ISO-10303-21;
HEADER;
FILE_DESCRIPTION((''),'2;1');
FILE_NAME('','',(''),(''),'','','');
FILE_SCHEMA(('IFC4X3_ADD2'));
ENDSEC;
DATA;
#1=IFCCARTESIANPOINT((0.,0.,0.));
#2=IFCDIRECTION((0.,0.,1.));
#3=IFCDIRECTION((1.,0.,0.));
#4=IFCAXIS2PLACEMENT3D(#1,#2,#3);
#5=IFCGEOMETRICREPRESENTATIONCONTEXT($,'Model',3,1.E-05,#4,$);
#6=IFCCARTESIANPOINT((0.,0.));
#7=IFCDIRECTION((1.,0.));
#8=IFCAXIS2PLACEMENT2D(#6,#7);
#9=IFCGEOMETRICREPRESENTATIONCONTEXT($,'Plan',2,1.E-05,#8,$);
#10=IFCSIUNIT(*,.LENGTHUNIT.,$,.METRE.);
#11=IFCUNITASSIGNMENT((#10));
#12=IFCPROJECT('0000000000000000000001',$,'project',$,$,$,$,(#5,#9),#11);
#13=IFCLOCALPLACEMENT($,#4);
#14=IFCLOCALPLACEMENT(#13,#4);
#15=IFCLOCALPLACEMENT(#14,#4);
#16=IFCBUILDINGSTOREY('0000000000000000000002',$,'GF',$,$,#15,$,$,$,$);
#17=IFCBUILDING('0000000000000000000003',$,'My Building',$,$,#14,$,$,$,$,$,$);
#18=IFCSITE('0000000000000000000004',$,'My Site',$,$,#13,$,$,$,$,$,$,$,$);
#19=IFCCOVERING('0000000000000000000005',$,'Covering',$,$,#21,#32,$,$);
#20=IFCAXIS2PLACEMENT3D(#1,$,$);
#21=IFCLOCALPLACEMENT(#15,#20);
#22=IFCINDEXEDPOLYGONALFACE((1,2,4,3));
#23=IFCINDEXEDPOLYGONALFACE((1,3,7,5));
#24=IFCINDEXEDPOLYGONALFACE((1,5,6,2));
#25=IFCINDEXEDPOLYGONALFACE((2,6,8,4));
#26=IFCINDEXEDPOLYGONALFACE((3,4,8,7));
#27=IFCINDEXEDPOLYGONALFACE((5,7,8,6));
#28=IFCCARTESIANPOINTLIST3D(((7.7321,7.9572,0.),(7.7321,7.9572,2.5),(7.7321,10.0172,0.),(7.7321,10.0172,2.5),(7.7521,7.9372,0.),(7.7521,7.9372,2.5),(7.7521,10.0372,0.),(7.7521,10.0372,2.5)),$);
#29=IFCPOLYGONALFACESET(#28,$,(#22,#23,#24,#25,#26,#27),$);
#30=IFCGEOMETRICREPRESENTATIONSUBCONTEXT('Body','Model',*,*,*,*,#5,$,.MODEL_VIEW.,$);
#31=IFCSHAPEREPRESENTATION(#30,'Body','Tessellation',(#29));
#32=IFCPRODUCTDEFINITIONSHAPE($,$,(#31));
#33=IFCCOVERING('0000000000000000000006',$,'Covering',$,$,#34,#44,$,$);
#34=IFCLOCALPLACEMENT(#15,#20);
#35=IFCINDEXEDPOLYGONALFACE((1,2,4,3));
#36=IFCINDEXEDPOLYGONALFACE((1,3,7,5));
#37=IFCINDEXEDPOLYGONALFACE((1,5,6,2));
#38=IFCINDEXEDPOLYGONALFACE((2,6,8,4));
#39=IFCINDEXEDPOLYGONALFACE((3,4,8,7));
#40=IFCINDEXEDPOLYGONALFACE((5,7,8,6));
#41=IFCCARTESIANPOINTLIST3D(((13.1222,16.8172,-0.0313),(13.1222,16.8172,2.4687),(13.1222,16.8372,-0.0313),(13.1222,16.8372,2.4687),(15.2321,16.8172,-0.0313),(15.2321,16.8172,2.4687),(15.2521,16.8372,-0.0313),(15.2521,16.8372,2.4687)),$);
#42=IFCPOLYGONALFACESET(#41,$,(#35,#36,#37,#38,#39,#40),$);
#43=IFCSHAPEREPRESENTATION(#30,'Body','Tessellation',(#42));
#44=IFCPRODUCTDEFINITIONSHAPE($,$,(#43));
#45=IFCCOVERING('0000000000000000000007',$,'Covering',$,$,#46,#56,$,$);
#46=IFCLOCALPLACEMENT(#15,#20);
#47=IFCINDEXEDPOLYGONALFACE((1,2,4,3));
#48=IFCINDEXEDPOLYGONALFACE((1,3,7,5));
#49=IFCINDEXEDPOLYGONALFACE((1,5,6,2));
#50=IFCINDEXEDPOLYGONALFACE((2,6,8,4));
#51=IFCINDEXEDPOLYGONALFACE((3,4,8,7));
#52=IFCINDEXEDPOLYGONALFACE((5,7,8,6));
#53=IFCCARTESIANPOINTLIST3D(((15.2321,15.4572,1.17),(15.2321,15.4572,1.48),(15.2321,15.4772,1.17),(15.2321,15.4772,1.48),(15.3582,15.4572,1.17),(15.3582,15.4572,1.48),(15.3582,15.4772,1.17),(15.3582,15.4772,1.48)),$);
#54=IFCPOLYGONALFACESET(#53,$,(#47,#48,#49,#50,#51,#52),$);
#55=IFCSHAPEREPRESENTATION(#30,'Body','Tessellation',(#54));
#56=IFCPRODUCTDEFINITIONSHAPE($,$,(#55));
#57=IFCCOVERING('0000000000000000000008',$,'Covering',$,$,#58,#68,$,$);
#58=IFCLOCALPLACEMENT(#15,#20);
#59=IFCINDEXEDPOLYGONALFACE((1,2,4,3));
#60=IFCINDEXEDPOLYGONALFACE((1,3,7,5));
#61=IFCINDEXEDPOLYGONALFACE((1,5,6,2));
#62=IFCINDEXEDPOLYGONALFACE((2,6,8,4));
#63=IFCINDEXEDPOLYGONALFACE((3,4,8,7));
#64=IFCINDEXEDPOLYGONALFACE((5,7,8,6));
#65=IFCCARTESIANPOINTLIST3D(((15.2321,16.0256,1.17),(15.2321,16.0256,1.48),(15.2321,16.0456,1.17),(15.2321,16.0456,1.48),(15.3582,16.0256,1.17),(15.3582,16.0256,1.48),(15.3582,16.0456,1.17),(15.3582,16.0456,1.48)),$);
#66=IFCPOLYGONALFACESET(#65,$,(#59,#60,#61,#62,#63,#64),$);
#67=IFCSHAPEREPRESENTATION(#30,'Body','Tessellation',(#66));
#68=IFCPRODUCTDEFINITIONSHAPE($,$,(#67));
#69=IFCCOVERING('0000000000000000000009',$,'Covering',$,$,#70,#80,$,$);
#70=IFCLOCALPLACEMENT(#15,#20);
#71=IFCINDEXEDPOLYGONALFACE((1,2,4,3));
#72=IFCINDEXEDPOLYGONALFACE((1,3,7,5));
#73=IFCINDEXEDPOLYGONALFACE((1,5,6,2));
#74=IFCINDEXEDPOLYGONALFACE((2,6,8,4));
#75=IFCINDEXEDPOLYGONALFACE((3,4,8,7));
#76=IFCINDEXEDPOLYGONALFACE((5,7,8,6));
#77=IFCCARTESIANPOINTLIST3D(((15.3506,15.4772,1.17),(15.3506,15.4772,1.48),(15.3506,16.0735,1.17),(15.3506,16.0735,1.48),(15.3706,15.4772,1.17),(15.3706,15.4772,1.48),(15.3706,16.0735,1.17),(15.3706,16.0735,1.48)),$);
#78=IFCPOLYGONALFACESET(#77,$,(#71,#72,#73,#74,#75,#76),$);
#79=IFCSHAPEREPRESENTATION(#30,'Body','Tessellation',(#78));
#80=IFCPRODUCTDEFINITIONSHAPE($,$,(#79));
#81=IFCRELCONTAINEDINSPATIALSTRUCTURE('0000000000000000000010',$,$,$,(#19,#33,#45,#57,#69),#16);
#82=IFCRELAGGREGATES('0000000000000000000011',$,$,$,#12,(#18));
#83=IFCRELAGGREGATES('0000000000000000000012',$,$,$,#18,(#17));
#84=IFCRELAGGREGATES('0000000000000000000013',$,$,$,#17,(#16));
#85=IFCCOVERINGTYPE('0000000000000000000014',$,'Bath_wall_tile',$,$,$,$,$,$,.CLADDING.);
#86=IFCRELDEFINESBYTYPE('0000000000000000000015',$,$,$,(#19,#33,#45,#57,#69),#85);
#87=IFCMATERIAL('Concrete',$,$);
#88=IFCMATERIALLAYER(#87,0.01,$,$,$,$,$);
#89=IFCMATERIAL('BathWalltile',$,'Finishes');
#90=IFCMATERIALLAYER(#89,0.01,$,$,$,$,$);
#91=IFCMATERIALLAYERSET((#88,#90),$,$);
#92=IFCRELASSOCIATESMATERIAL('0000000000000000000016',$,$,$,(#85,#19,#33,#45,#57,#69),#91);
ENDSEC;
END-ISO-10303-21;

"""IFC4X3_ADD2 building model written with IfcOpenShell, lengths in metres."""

from ifc_helpers import new_model, si_unit, frame, origin_with_axes, origin_2d_with_axis, place, context, subcontext, project, spatial, line, indexed_curve, outline, extrude, material, layer, layer_set, layer_usage, type_object, element, save


model = new_model("IFC4X3_ADD2")

# Units and contexts
model_context = context("Model", 3, precision=1e-05, world=origin_with_axes())
plan_context = context("Plan", 2, precision=1e-05, world=origin_2d_with_axis())
body_context_1 = subcontext(model_context, "Body", "Model", "MODEL_VIEW")
ifc_project = project(units=[si_unit("LENGTHUNIT", "METRE")], contexts=[model_context, plan_context])

# Site, building, storey
site_placement = place(None, origin_with_axes())
site = spatial("IfcSite", under=ifc_project, at=site_placement, Name="My Site")
building_placement = place(site_placement, origin_with_axes())
building = spatial("IfcBuilding", under=site, at=building_placement, Name="My Building")
storey_placement = place(building_placement, origin_with_axes())
storey = spatial("IfcBuildingStorey", under=building, at=storey_placement, Name="GF")

# Coverings
ifc_material_1 = material(Name="Concrete")
ifc_layer_1 = layer(ifc_material_1, 0.01)
ifc_material_2 = material(Name="BathWalltile", Category="Finishes")
ifc_layer_2 = layer(ifc_material_2, 0.01)
ifc_layer_set_1 = layer_set([ifc_layer_1, ifc_layer_2])
covering_type = type_object("IfcCoveringType", Name="Bath_wall_tile", PredefinedType="CLADDING", material=ifc_layer_set_1)
ifc_layer_usage_1 = layer_usage(ifc_layer_set_1, "AXIS2", "NEGATIVE", 0.0)
covering_1_placement = place(storey_placement, frame((7.7521, 10.0372, 0.0), z_axis=(0.0, 0.0, 1.0), x_axis=(0.0, -1.0, 0.0)))
element("IfcCovering", 1, at=covering_1_placement, inside=storey, type_object=covering_type, material=ifc_layer_usage_1, Name="Covering", context=body_context_1, shape_type="SweptSolid", body=[
    extrude(outline(indexed_curve([(0.02, -0.02), (0.0, 0.0), (2.1, 0.0), (2.08, -0.02)], segments=[line(1, 2, 3, 4, 1)])), origin_with_axes(), (0.0, 0.0, 1.0), 2.5),
])
ifc_layer_usage_2 = layer_usage(ifc_layer_set_1, "AXIS2", "POSITIVE", 0.0)
covering_2_placement = place(storey_placement, frame((15.2521, 16.8372, -0.0313), z_axis=(0.0, 0.0, 1.0), x_axis=(-1.0, 0.0, 0.0)))
element("IfcCovering", 2, at=covering_2_placement, inside=storey, type_object=covering_type, material=ifc_layer_usage_2, Name="Covering", context=body_context_1, shape_type="SweptSolid", body=[
    extrude(outline(indexed_curve([(0.0, 0.0), (0.02, 0.02), (2.1299, 0.02), (2.1299, 0.0)], segments=[line(1, 2, 3, 4, 1)])), origin_with_axes(), (0.0, 0.0, 1.0), 2.5),
])
ifc_layer_usage_3 = layer_usage(ifc_layer_set_1, "AXIS2", "POSITIVE", 0.0)
covering_3_placement = place(storey_placement, frame((15.2321, 15.4572, 1.17), z_axis=(0.0, 0.0, 1.0), x_axis=(1.0, 0.0, 0.0)))
element("IfcCovering", 3, at=covering_3_placement, inside=storey, type_object=covering_type, material=ifc_layer_usage_3, Name="Covering", context=body_context_1, shape_type="SweptSolid", body=[
    extrude(outline(indexed_curve([(0.0, 0.0), (0.0, 0.02), (0.1261, 0.02), (0.1261, 0.0)], segments=[line(1, 2, 3, 4, 1)])), origin_with_axes(), (0.0, 0.0, 1.0), 0.31),
])
ifc_layer_usage_4 = layer_usage(ifc_layer_set_1, "AXIS2", "NEGATIVE", 0.0)
covering_4_placement = place(storey_placement, frame((15.2321, 16.0456, 1.17), z_axis=(0.0, 0.0, 1.0), x_axis=(1.0, 0.0, 0.0)))
element("IfcCovering", 4, at=covering_4_placement, inside=storey, type_object=covering_type, material=ifc_layer_usage_4, Name="Covering", context=body_context_1, shape_type="SweptSolid", body=[
    extrude(outline(indexed_curve([(0.0, -0.02), (0.0, 0.0), (0.1261, 0.0), (0.1261, -0.02)], segments=[line(1, 2, 3, 4, 1)])), origin_with_axes(), (0.0, 0.0, 1.0), 0.31),
])
ifc_layer_usage_5 = layer_usage(ifc_layer_set_1, "AXIS2", "POSITIVE", 0.0)
covering_5_placement = place(storey_placement, frame((15.3706, 15.4772, 1.17), z_axis=(0.0, 0.0, 1.0), x_axis=(0.0, 1.0, 0.0)))
element("IfcCovering", 5, at=covering_5_placement, inside=storey, type_object=covering_type, material=ifc_layer_usage_5, Name="Covering", context=body_context_1, shape_type="SweptSolid", body=[
    extrude(outline(indexed_curve([(0.0, 0.0), (0.0, 0.02), (0.5963, 0.02), (0.5963, 0.0)], segments=[line(1, 2, 3, 4, 1)])), origin_with_axes(), (0.0, 0.0, 1.0), 0.31),
])

save(model, "model.ifc")
